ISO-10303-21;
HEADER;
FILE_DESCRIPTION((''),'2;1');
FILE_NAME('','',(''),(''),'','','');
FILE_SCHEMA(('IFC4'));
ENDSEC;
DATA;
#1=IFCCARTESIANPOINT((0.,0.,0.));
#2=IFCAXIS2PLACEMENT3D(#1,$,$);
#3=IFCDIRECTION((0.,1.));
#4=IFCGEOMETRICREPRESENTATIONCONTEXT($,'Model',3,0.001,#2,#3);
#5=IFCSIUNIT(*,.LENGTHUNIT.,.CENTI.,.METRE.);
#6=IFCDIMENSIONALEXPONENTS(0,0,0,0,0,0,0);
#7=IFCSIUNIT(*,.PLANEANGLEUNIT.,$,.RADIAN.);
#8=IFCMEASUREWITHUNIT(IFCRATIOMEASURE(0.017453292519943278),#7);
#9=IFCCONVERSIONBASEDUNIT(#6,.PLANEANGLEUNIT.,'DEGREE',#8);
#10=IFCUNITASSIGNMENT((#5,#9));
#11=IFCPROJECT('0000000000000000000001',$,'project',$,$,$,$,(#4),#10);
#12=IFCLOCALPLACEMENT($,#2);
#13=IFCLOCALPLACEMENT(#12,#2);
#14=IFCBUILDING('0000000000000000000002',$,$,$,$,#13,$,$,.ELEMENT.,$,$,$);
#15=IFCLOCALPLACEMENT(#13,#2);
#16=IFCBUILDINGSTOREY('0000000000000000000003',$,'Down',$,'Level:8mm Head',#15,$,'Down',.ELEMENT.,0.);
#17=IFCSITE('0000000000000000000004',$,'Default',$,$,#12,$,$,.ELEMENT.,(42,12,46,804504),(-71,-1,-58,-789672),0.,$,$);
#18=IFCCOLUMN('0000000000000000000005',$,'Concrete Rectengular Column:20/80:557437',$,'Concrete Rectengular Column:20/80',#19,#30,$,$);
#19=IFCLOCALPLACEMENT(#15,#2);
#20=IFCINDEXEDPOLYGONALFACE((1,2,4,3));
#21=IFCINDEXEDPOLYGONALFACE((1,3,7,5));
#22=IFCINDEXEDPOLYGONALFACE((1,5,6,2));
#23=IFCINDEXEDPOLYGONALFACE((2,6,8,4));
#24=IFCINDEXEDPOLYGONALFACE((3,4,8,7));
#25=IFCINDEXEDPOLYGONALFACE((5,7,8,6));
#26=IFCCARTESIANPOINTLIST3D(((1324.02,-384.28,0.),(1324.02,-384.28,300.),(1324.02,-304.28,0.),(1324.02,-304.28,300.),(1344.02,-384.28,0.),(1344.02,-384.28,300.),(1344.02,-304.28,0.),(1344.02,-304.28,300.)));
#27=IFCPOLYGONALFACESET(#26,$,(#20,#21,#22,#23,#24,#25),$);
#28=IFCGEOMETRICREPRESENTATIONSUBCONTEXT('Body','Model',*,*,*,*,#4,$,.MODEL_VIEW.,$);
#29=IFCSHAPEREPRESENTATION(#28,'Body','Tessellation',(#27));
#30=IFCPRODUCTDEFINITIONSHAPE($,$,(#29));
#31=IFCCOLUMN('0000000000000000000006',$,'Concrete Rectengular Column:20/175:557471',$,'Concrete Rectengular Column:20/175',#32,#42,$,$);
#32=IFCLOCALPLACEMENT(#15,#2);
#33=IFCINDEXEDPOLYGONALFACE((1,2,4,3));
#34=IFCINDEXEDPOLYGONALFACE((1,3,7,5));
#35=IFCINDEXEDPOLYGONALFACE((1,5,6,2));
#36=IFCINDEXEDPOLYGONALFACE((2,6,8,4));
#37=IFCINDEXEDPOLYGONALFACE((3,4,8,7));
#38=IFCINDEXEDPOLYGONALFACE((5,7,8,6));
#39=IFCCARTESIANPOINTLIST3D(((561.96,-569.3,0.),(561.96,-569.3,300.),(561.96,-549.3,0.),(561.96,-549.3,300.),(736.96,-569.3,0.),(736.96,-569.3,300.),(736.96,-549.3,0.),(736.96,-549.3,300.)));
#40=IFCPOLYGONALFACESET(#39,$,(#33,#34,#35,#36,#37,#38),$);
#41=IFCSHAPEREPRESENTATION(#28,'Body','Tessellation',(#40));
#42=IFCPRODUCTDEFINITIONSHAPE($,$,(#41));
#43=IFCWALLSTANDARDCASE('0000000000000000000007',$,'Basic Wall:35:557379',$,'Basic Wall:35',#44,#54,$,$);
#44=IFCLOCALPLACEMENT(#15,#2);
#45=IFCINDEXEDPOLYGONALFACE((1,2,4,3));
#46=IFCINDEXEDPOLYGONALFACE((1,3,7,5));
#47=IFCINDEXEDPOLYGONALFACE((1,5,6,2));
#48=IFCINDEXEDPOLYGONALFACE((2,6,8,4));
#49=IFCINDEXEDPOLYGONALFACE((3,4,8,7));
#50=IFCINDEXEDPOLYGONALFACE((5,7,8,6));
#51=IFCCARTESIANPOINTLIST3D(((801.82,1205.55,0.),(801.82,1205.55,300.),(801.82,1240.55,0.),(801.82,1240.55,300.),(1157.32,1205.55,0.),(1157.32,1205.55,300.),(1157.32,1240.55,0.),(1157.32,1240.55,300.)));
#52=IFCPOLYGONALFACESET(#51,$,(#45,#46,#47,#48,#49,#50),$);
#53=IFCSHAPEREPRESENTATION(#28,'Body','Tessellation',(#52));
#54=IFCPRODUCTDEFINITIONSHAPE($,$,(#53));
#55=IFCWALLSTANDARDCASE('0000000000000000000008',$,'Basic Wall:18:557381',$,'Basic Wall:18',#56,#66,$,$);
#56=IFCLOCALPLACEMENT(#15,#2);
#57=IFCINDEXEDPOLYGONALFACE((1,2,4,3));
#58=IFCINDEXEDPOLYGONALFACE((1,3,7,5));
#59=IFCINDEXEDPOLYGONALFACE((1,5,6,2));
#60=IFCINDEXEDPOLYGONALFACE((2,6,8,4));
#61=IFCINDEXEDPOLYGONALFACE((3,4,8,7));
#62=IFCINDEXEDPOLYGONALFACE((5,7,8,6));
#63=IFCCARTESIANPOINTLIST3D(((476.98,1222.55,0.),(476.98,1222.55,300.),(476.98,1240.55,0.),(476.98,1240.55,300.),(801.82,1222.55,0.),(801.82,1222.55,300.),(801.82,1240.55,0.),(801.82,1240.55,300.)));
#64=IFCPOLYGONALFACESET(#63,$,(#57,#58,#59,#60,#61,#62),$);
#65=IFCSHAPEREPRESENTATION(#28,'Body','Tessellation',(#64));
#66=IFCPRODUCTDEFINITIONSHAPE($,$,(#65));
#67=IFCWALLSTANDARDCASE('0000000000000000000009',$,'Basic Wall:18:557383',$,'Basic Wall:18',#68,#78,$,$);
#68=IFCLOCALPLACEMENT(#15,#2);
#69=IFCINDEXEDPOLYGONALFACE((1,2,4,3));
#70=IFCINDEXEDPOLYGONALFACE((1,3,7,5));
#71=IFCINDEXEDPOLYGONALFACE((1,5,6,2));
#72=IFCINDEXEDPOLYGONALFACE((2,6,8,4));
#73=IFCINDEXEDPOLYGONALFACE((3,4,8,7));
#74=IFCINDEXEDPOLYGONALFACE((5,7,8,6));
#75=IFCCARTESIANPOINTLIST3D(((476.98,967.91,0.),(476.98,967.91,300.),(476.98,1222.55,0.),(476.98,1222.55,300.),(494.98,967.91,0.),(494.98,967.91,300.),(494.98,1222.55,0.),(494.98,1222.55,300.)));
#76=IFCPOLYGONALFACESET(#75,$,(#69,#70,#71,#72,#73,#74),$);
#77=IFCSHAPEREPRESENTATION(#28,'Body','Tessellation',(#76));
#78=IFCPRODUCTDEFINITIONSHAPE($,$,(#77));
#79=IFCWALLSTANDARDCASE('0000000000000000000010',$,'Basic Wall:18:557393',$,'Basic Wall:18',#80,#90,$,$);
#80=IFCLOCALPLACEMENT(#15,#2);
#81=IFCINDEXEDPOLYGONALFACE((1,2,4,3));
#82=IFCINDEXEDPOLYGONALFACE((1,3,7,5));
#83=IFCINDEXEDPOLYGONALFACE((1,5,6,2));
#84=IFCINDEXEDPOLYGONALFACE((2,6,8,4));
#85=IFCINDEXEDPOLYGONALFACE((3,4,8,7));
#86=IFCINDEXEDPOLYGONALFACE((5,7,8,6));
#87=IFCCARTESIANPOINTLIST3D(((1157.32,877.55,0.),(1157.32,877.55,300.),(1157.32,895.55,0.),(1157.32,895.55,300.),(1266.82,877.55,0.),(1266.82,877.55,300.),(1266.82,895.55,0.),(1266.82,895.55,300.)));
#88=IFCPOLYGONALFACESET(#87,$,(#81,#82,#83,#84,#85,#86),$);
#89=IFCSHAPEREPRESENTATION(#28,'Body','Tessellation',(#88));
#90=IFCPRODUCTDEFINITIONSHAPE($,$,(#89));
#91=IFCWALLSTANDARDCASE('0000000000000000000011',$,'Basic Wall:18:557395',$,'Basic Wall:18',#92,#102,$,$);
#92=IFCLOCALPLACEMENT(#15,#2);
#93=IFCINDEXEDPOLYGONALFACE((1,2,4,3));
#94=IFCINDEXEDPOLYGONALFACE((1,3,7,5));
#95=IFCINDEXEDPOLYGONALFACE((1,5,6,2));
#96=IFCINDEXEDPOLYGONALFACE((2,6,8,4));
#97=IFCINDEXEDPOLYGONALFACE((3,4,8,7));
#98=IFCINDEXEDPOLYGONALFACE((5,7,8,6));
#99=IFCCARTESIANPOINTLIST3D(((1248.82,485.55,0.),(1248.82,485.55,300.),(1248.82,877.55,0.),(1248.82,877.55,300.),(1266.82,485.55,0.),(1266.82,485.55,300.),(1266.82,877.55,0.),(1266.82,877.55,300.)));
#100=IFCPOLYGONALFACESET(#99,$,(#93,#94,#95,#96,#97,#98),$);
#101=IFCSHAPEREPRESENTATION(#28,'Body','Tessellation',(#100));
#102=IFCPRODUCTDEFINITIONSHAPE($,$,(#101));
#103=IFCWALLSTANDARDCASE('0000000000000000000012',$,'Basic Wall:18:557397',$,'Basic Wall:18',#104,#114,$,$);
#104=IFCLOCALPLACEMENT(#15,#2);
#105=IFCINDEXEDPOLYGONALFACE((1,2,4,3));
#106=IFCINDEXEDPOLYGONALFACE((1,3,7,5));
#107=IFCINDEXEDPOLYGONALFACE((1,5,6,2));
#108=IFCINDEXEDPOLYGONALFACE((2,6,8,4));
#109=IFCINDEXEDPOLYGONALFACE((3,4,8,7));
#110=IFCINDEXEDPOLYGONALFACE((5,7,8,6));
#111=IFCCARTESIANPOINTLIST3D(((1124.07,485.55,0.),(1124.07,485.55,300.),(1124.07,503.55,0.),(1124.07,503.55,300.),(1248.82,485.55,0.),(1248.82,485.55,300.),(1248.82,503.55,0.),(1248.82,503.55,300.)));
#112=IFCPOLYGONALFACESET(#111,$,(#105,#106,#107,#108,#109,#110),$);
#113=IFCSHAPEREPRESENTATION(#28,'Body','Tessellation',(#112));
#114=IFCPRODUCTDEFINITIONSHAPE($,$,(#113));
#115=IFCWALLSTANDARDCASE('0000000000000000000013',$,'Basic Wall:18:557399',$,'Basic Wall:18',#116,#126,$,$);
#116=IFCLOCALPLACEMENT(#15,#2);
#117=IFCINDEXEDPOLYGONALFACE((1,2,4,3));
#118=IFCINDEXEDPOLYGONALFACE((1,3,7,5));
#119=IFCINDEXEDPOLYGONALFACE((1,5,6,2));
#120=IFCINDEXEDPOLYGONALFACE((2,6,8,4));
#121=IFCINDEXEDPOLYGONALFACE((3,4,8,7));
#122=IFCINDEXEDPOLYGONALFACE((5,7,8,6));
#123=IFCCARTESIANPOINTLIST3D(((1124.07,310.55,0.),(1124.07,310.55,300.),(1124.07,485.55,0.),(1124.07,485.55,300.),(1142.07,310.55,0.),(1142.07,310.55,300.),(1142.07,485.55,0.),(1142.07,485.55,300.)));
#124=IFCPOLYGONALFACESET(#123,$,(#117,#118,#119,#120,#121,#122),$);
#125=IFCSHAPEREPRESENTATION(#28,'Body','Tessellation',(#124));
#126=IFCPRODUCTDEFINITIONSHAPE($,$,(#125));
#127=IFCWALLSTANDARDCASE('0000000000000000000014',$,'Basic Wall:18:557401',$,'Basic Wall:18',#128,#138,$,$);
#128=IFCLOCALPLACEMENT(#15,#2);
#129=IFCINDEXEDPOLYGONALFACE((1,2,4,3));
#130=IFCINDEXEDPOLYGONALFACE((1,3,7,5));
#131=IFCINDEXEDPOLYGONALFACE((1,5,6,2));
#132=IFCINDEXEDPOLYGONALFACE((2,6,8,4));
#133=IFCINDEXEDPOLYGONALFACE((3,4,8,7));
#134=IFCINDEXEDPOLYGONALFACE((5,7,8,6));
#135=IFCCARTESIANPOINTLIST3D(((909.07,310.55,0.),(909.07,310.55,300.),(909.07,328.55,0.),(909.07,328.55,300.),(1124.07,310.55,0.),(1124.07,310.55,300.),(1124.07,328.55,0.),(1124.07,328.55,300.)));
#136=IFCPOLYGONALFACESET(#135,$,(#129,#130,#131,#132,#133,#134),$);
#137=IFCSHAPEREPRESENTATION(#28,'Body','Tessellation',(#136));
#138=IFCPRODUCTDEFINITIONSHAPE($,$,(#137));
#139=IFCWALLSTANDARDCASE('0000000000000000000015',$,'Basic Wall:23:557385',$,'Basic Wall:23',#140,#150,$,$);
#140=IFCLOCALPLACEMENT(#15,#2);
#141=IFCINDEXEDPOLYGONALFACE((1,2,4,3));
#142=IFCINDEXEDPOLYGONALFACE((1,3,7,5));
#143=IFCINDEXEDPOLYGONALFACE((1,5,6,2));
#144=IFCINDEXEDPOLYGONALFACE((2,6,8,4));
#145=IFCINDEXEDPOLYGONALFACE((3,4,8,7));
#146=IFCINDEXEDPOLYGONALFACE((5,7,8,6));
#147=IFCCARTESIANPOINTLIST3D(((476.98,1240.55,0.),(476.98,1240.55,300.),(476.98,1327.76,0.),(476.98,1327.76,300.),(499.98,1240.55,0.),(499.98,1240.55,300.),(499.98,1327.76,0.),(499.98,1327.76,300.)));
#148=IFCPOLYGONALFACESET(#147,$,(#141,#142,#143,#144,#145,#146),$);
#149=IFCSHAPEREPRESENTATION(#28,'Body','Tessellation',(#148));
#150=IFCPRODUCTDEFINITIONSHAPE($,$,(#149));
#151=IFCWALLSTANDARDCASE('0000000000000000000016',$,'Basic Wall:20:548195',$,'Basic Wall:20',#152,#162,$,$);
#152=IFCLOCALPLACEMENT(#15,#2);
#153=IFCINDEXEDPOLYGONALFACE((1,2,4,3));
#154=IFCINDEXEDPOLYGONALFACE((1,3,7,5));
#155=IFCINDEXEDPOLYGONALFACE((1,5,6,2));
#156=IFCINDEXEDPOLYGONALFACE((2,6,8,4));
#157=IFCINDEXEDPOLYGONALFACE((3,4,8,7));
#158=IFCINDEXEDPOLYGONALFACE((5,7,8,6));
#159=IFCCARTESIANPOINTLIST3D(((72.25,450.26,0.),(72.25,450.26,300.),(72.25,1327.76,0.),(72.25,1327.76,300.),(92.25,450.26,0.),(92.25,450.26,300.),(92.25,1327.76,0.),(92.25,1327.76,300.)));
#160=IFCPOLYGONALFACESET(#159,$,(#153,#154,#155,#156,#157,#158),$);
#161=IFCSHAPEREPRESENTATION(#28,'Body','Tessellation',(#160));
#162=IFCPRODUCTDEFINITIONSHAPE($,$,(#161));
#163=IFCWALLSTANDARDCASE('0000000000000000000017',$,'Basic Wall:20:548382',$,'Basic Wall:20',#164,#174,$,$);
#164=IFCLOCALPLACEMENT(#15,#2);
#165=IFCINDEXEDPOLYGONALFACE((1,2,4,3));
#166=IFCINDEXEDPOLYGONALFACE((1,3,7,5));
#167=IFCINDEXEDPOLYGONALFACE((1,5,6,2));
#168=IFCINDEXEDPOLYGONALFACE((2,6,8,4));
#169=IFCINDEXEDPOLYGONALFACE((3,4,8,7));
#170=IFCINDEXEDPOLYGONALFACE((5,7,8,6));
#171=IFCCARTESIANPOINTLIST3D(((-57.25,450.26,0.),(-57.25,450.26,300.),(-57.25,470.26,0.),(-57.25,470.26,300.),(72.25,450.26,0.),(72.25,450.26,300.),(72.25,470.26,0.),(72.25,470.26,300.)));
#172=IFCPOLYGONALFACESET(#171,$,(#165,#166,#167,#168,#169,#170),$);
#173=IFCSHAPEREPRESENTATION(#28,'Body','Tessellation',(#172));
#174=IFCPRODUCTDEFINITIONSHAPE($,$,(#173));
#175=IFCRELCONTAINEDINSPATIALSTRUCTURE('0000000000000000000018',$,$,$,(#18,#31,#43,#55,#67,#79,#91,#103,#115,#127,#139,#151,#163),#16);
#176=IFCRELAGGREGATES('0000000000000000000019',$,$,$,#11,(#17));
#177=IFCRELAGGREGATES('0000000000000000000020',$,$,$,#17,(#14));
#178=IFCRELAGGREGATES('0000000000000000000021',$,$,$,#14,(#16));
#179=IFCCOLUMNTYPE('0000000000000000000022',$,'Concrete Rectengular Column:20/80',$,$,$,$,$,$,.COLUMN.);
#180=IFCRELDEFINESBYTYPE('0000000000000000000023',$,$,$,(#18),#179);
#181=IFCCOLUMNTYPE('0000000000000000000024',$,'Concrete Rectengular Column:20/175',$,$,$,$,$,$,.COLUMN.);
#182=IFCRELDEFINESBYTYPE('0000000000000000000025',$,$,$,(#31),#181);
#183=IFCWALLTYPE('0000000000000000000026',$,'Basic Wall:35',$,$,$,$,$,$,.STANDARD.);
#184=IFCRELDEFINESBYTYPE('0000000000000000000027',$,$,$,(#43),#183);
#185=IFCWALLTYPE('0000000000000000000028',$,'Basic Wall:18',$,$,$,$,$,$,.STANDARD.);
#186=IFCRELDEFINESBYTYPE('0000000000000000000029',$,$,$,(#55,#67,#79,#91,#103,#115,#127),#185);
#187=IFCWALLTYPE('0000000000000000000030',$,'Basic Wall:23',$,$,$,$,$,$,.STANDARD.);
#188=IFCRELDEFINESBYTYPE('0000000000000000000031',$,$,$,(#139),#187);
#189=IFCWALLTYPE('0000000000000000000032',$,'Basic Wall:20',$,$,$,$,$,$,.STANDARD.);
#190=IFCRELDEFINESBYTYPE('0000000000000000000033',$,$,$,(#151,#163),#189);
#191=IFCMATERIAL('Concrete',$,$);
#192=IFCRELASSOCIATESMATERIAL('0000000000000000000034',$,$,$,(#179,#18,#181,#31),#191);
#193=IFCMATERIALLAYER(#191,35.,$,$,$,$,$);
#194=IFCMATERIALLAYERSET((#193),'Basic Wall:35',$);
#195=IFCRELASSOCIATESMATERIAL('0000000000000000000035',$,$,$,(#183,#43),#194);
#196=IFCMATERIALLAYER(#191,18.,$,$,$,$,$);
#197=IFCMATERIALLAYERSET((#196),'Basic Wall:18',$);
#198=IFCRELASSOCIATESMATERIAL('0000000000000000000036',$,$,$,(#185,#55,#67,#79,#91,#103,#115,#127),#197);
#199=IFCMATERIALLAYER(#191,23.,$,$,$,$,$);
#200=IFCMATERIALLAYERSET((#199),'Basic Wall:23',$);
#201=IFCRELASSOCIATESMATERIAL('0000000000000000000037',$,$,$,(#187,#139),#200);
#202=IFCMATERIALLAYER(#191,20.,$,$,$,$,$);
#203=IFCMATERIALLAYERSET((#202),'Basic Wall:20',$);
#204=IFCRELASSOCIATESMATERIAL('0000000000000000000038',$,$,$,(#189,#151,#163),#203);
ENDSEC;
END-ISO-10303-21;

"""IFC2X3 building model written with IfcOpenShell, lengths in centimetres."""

from ifc_helpers import new_model, entity, si_unit, converted_unit, direction, frame, frame_2d, origin, origin_2d_with_axis, place, context, subcontext, project, spatial, rectangle, extrude, source, transform, mapped, material, layer, layer_set, layer_usage, type_object, type_shapes, element, save


model = new_model("IFC2X3")

# Units and contexts
model_context = context("Model", 3, precision=0.001, world=origin(), true_north=direction((0.0, 1.0)))
body_context = subcontext(model_context, "Body", "Model", "MODEL_VIEW")
ifc_project = project(units=[si_unit("LENGTHUNIT", "METRE", prefix="CENTI"), converted_unit("PLANEANGLEUNIT", "DEGREE", entity("IfcRatioMeasure", 0.017453292519943278), si_unit("PLANEANGLEUNIT", "RADIAN"), dimensions=[0, 0, 0, 0, 0, 0, 0])], contexts=[model_context])

# Site, building, storey
site_placement = place(None, origin())
site = spatial("IfcSite", under=ifc_project, at=site_placement, Name="Default", CompositionType="ELEMENT", RefLatitude=(42, 12, 46, 804504), RefLongitude=(-71, -1, -58, -789672), RefElevation=0.0)
building_placement = place(site_placement, origin())
building = spatial("IfcBuilding", under=site, at=building_placement, CompositionType="ELEMENT")
storey_placement = place(building_placement, origin())
storey = spatial("IfcBuildingStorey", under=building, at=storey_placement, Name="Down", ObjectType="Level:8mm Head", LongName="Down", CompositionType="ELEMENT", Elevation=0.0)

# Columns
ifc_material = material(Name="Concrete")
column_type_1 = type_object("IfcColumnType", Name="Concrete Rectengular Column:20/80", PredefinedType="COLUMN", material=ifc_material)
shared_shape_1 = source(origin(), body_context, "Body", "SweptSolid", [
    extrude(rectangle(XDim=80.0, YDim=20.0, at=frame_2d((0.0, 0.0), x_axis=(1.0, 0.0))), frame((1334.02, -344.28, 0.0), z_axis=(0.0, 0.0, 1.0), x_axis=(0.0, -1.0, 0.0)), (0.0, 0.0, 1.0), 300.0),
])
type_shapes(column_type_1, [shared_shape_1])
column_1_placement = place(storey_placement, origin())
element("IfcColumn", 1, at=column_1_placement, inside=storey, type_object=column_type_1, material=ifc_material, Name="Concrete Rectengular Column:20/80:557437", ObjectType="Concrete Rectengular Column:20/80", context=body_context, shape_type="MappedRepresentation", body=[
    mapped(shared_shape_1, transform((0.0, 0.0, 0.0), scale=1.0)),
])
column_type_2 = type_object("IfcColumnType", Name="Concrete Rectengular Column:20/175", PredefinedType="COLUMN", material=ifc_material)
shared_shape_2 = source(origin(), body_context, "Body", "SweptSolid", [
    extrude(rectangle(XDim=20.0, YDim=175.0, at=origin_2d_with_axis()), frame((649.46, -559.3, 0.0), z_axis=(0.0, 0.0, 1.0), x_axis=(0.0, -1.0, 0.0)), (0.0, 0.0, 1.0), 300.0),
])
type_shapes(column_type_2, [shared_shape_2])
column_2_placement = place(storey_placement, origin())
element("IfcColumn", 2, at=column_2_placement, inside=storey, type_object=column_type_2, material=ifc_material, Name="Concrete Rectengular Column:20/175:557471", ObjectType="Concrete Rectengular Column:20/175", context=body_context, shape_type="MappedRepresentation", body=[
    mapped(shared_shape_2, transform((0.0, 0.0, 0.0), scale=1.0)),
])

# Walls
ifc_layer_1 = layer(ifc_material, 35.0)
ifc_layer_set_1 = layer_set([ifc_layer_1], Name="Basic Wall:35")
ifc_layer_usage_1 = layer_usage(ifc_layer_set_1, "AXIS2", "POSITIVE", -17.5)
wall_type_1 = type_object("IfcWallType", Name="Basic Wall:35", PredefinedType="STANDARD", material=ifc_layer_set_1)
wall_1_placement = place(storey_placement, frame((1157.32, 1223.05, 0.0), z_axis=(0.0, 0.0, 1.0), x_axis=(-1.0, 0.0, 0.0)))
element("IfcWallStandardCase", 3, at=wall_1_placement, inside=storey, type_object=wall_type_1, material=ifc_layer_usage_1, Name="Basic Wall:35:557379", ObjectType="Basic Wall:35", context=body_context, shape_type="SweptSolid", body=[
    extrude(rectangle(XDim=355.5, YDim=35.0, at=frame_2d((177.75, 0.0), x_axis=(-1.0, 0.0))), origin(), (0.0, 0.0, 1.0), 300.0),
])
ifc_layer_2 = layer(ifc_material, 18.0)
ifc_layer_set_2 = layer_set([ifc_layer_2], Name="Basic Wall:18")
ifc_layer_usage_2 = layer_usage(ifc_layer_set_2, "AXIS2", "POSITIVE", -9.0)
wall_type_2 = type_object("IfcWallType", Name="Basic Wall:18", PredefinedType="STANDARD", material=ifc_layer_set_2)
wall_2_placement = place(storey_placement, frame((801.82, 1231.55, 0.0), z_axis=(0.0, 0.0, 1.0), x_axis=(-1.0, 0.0, 0.0)))
element("IfcWallStandardCase", 4, at=wall_2_placement, inside=storey, type_object=wall_type_2, material=ifc_layer_usage_2, Name="Basic Wall:18:557381", ObjectType="Basic Wall:18", context=body_context, shape_type="SweptSolid", body=[
    extrude(rectangle(XDim=324.84, YDim=18.0, at=frame_2d((162.42, 0.0), x_axis=(-1.0, 0.0))), origin(), (0.0, 0.0, 1.0), 300.0),
])
ifc_layer_usage_3 = layer_usage(ifc_layer_set_2, "AXIS2", "POSITIVE", -9.0)
wall_3_placement = place(storey_placement, frame((485.98, 1222.55, 0.0), z_axis=(0.0, 0.0, 1.0), x_axis=(0.0, -1.0, 0.0)))
element("IfcWallStandardCase", 5, at=wall_3_placement, inside=storey, type_object=wall_type_2, material=ifc_layer_usage_3, Name="Basic Wall:18:557383", ObjectType="Basic Wall:18", context=body_context, shape_type="SweptSolid", body=[
    extrude(rectangle(XDim=254.64, YDim=18.0, at=frame_2d((127.32, 0.0), x_axis=(-1.0, 0.0))), origin(), (0.0, 0.0, 1.0), 300.0),
])
ifc_layer_usage_4 = layer_usage(ifc_layer_set_2, "AXIS2", "POSITIVE", -9.0)
wall_4_placement = place(storey_placement, frame((1157.32, 886.55, 0.0)))
element("IfcWallStandardCase", 6, at=wall_4_placement, inside=storey, type_object=wall_type_2, material=ifc_layer_usage_4, Name="Basic Wall:18:557393", ObjectType="Basic Wall:18", context=body_context, shape_type="SweptSolid", body=[
    extrude(rectangle(XDim=109.5, YDim=18.0, at=frame_2d((54.75, 0.0), x_axis=(-1.0, 0.0))), origin(), (0.0, 0.0, 1.0), 300.0),
])
ifc_layer_usage_5 = layer_usage(ifc_layer_set_2, "AXIS2", "NEGATIVE", 9.0)
wall_5_placement = place(storey_placement, frame((1257.82, 877.55, 0.0), z_axis=(0.0, 0.0, 1.0), x_axis=(0.0, -1.0, 0.0)))
element("IfcWallStandardCase", 7, at=wall_5_placement, inside=storey, type_object=wall_type_2, material=ifc_layer_usage_5, Name="Basic Wall:18:557395", ObjectType="Basic Wall:18", context=body_context, shape_type="SweptSolid", body=[
    extrude(rectangle(XDim=392.0, YDim=18.0, at=frame_2d((196.0, 0.0), x_axis=(-1.0, 0.0))), origin(), (0.0, 0.0, 1.0), 300.0),
])
ifc_layer_usage_6 = layer_usage(ifc_layer_set_2, "AXIS2", "NEGATIVE", 9.0)
wall_6_placement = place(storey_placement, frame((1248.82, 494.55, 0.0), z_axis=(0.0, 0.0, 1.0), x_axis=(-1.0, 0.0, 0.0)))
element("IfcWallStandardCase", 8, at=wall_6_placement, inside=storey, type_object=wall_type_2, material=ifc_layer_usage_6, Name="Basic Wall:18:557397", ObjectType="Basic Wall:18", context=body_context, shape_type="SweptSolid", body=[
    extrude(rectangle(XDim=124.75, YDim=18.0, at=frame_2d((62.38, 0.0), x_axis=(-1.0, 0.0))), origin(), (0.0, 0.0, 1.0), 300.0),
])
ifc_layer_usage_7 = layer_usage(ifc_layer_set_2, "AXIS2", "POSITIVE", -9.0)
wall_7_placement = place(storey_placement, frame((1133.07, 485.55, 0.0), z_axis=(0.0, 0.0, 1.0), x_axis=(0.0, -1.0, 0.0)))
element("IfcWallStandardCase", 9, at=wall_7_placement, inside=storey, type_object=wall_type_2, material=ifc_layer_usage_7, Name="Basic Wall:18:557399", ObjectType="Basic Wall:18", context=body_context, shape_type="SweptSolid", body=[
    extrude(rectangle(XDim=175.0, YDim=18.0, at=frame_2d((87.5, 0.0), x_axis=(-1.0, 0.0))), origin(), (0.0, 0.0, 1.0), 300.0),
])
ifc_layer_usage_8 = layer_usage(ifc_layer_set_2, "AXIS2", "NEGATIVE", 9.0)
wall_8_placement = place(storey_placement, frame((1124.07, 319.55, 0.0), z_axis=(0.0, 0.0, 1.0), x_axis=(-1.0, 0.0, 0.0)))
element("IfcWallStandardCase", 10, at=wall_8_placement, inside=storey, type_object=wall_type_2, material=ifc_layer_usage_8, Name="Basic Wall:18:557401", ObjectType="Basic Wall:18", context=body_context, shape_type="SweptSolid", body=[
    extrude(rectangle(XDim=215.0, YDim=18.0, at=frame_2d((107.5, 0.0), x_axis=(-1.0, 0.0))), origin(), (0.0, 0.0, 1.0), 300.0),
])
ifc_layer_3 = layer(ifc_material, 23.0)
ifc_layer_set_3 = layer_set([ifc_layer_3], Name="Basic Wall:23")
ifc_layer_usage_9 = layer_usage(ifc_layer_set_3, "AXIS2", "NEGATIVE", 11.5)
wall_type_3 = type_object("IfcWallType", Name="Basic Wall:23", PredefinedType="STANDARD", material=ifc_layer_set_3)
wall_9_placement = place(storey_placement, frame((488.48, 1240.55, 0.0), z_axis=(0.0, 0.0, 1.0), x_axis=(0.0, 1.0, 0.0)))
element("IfcWallStandardCase", 11, at=wall_9_placement, inside=storey, type_object=wall_type_3, material=ifc_layer_usage_9, Name="Basic Wall:23:557385", ObjectType="Basic Wall:23", context=body_context, shape_type="SweptSolid", body=[
    extrude(rectangle(XDim=87.21, YDim=23.0, at=frame_2d((43.61, 0.0), x_axis=(-1.0, 0.0))), origin(), (0.0, 0.0, 1.0), 300.0),
])
ifc_layer_4 = layer(ifc_material, 20.0)
ifc_layer_set_4 = layer_set([ifc_layer_4], Name="Basic Wall:20")
ifc_layer_usage_10 = layer_usage(ifc_layer_set_4, "AXIS2", "NEGATIVE", 10.0)
wall_type_4 = type_object("IfcWallType", Name="Basic Wall:20", PredefinedType="STANDARD", material=ifc_layer_set_4)
wall_10_placement = place(storey_placement, frame((82.25, 1327.76, 0.0), z_axis=(0.0, 0.0, 1.0), x_axis=(0.0, -1.0, 0.0)))
element("IfcWallStandardCase", 12, at=wall_10_placement, inside=storey, type_object=wall_type_4, material=ifc_layer_usage_10, Name="Basic Wall:20:548195", ObjectType="Basic Wall:20", context=body_context, shape_type="SweptSolid", body=[
    extrude(rectangle(XDim=877.5, YDim=20.0, at=frame_2d((438.75, 0.0), x_axis=(-1.0, 0.0))), origin(), (0.0, 0.0, 1.0), 300.0),
])
ifc_layer_usage_11 = layer_usage(ifc_layer_set_4, "AXIS2", "NEGATIVE", 10.0)
wall_11_placement = place(storey_placement, frame((72.25, 460.26, 0.0), z_axis=(0.0, 0.0, 1.0), x_axis=(-1.0, 0.0, 0.0)))
element("IfcWallStandardCase", 13, at=wall_11_placement, inside=storey, type_object=wall_type_4, material=ifc_layer_usage_11, Name="Basic Wall:20:548382", ObjectType="Basic Wall:20", context=body_context, shape_type="SweptSolid", body=[
    extrude(rectangle(XDim=129.5, YDim=20.0, at=frame_2d((64.75, 0.0), x_axis=(-1.0, 0.0))), origin(), (0.0, 0.0, 1.0), 300.0),
])

save(model, "model.ifc")
